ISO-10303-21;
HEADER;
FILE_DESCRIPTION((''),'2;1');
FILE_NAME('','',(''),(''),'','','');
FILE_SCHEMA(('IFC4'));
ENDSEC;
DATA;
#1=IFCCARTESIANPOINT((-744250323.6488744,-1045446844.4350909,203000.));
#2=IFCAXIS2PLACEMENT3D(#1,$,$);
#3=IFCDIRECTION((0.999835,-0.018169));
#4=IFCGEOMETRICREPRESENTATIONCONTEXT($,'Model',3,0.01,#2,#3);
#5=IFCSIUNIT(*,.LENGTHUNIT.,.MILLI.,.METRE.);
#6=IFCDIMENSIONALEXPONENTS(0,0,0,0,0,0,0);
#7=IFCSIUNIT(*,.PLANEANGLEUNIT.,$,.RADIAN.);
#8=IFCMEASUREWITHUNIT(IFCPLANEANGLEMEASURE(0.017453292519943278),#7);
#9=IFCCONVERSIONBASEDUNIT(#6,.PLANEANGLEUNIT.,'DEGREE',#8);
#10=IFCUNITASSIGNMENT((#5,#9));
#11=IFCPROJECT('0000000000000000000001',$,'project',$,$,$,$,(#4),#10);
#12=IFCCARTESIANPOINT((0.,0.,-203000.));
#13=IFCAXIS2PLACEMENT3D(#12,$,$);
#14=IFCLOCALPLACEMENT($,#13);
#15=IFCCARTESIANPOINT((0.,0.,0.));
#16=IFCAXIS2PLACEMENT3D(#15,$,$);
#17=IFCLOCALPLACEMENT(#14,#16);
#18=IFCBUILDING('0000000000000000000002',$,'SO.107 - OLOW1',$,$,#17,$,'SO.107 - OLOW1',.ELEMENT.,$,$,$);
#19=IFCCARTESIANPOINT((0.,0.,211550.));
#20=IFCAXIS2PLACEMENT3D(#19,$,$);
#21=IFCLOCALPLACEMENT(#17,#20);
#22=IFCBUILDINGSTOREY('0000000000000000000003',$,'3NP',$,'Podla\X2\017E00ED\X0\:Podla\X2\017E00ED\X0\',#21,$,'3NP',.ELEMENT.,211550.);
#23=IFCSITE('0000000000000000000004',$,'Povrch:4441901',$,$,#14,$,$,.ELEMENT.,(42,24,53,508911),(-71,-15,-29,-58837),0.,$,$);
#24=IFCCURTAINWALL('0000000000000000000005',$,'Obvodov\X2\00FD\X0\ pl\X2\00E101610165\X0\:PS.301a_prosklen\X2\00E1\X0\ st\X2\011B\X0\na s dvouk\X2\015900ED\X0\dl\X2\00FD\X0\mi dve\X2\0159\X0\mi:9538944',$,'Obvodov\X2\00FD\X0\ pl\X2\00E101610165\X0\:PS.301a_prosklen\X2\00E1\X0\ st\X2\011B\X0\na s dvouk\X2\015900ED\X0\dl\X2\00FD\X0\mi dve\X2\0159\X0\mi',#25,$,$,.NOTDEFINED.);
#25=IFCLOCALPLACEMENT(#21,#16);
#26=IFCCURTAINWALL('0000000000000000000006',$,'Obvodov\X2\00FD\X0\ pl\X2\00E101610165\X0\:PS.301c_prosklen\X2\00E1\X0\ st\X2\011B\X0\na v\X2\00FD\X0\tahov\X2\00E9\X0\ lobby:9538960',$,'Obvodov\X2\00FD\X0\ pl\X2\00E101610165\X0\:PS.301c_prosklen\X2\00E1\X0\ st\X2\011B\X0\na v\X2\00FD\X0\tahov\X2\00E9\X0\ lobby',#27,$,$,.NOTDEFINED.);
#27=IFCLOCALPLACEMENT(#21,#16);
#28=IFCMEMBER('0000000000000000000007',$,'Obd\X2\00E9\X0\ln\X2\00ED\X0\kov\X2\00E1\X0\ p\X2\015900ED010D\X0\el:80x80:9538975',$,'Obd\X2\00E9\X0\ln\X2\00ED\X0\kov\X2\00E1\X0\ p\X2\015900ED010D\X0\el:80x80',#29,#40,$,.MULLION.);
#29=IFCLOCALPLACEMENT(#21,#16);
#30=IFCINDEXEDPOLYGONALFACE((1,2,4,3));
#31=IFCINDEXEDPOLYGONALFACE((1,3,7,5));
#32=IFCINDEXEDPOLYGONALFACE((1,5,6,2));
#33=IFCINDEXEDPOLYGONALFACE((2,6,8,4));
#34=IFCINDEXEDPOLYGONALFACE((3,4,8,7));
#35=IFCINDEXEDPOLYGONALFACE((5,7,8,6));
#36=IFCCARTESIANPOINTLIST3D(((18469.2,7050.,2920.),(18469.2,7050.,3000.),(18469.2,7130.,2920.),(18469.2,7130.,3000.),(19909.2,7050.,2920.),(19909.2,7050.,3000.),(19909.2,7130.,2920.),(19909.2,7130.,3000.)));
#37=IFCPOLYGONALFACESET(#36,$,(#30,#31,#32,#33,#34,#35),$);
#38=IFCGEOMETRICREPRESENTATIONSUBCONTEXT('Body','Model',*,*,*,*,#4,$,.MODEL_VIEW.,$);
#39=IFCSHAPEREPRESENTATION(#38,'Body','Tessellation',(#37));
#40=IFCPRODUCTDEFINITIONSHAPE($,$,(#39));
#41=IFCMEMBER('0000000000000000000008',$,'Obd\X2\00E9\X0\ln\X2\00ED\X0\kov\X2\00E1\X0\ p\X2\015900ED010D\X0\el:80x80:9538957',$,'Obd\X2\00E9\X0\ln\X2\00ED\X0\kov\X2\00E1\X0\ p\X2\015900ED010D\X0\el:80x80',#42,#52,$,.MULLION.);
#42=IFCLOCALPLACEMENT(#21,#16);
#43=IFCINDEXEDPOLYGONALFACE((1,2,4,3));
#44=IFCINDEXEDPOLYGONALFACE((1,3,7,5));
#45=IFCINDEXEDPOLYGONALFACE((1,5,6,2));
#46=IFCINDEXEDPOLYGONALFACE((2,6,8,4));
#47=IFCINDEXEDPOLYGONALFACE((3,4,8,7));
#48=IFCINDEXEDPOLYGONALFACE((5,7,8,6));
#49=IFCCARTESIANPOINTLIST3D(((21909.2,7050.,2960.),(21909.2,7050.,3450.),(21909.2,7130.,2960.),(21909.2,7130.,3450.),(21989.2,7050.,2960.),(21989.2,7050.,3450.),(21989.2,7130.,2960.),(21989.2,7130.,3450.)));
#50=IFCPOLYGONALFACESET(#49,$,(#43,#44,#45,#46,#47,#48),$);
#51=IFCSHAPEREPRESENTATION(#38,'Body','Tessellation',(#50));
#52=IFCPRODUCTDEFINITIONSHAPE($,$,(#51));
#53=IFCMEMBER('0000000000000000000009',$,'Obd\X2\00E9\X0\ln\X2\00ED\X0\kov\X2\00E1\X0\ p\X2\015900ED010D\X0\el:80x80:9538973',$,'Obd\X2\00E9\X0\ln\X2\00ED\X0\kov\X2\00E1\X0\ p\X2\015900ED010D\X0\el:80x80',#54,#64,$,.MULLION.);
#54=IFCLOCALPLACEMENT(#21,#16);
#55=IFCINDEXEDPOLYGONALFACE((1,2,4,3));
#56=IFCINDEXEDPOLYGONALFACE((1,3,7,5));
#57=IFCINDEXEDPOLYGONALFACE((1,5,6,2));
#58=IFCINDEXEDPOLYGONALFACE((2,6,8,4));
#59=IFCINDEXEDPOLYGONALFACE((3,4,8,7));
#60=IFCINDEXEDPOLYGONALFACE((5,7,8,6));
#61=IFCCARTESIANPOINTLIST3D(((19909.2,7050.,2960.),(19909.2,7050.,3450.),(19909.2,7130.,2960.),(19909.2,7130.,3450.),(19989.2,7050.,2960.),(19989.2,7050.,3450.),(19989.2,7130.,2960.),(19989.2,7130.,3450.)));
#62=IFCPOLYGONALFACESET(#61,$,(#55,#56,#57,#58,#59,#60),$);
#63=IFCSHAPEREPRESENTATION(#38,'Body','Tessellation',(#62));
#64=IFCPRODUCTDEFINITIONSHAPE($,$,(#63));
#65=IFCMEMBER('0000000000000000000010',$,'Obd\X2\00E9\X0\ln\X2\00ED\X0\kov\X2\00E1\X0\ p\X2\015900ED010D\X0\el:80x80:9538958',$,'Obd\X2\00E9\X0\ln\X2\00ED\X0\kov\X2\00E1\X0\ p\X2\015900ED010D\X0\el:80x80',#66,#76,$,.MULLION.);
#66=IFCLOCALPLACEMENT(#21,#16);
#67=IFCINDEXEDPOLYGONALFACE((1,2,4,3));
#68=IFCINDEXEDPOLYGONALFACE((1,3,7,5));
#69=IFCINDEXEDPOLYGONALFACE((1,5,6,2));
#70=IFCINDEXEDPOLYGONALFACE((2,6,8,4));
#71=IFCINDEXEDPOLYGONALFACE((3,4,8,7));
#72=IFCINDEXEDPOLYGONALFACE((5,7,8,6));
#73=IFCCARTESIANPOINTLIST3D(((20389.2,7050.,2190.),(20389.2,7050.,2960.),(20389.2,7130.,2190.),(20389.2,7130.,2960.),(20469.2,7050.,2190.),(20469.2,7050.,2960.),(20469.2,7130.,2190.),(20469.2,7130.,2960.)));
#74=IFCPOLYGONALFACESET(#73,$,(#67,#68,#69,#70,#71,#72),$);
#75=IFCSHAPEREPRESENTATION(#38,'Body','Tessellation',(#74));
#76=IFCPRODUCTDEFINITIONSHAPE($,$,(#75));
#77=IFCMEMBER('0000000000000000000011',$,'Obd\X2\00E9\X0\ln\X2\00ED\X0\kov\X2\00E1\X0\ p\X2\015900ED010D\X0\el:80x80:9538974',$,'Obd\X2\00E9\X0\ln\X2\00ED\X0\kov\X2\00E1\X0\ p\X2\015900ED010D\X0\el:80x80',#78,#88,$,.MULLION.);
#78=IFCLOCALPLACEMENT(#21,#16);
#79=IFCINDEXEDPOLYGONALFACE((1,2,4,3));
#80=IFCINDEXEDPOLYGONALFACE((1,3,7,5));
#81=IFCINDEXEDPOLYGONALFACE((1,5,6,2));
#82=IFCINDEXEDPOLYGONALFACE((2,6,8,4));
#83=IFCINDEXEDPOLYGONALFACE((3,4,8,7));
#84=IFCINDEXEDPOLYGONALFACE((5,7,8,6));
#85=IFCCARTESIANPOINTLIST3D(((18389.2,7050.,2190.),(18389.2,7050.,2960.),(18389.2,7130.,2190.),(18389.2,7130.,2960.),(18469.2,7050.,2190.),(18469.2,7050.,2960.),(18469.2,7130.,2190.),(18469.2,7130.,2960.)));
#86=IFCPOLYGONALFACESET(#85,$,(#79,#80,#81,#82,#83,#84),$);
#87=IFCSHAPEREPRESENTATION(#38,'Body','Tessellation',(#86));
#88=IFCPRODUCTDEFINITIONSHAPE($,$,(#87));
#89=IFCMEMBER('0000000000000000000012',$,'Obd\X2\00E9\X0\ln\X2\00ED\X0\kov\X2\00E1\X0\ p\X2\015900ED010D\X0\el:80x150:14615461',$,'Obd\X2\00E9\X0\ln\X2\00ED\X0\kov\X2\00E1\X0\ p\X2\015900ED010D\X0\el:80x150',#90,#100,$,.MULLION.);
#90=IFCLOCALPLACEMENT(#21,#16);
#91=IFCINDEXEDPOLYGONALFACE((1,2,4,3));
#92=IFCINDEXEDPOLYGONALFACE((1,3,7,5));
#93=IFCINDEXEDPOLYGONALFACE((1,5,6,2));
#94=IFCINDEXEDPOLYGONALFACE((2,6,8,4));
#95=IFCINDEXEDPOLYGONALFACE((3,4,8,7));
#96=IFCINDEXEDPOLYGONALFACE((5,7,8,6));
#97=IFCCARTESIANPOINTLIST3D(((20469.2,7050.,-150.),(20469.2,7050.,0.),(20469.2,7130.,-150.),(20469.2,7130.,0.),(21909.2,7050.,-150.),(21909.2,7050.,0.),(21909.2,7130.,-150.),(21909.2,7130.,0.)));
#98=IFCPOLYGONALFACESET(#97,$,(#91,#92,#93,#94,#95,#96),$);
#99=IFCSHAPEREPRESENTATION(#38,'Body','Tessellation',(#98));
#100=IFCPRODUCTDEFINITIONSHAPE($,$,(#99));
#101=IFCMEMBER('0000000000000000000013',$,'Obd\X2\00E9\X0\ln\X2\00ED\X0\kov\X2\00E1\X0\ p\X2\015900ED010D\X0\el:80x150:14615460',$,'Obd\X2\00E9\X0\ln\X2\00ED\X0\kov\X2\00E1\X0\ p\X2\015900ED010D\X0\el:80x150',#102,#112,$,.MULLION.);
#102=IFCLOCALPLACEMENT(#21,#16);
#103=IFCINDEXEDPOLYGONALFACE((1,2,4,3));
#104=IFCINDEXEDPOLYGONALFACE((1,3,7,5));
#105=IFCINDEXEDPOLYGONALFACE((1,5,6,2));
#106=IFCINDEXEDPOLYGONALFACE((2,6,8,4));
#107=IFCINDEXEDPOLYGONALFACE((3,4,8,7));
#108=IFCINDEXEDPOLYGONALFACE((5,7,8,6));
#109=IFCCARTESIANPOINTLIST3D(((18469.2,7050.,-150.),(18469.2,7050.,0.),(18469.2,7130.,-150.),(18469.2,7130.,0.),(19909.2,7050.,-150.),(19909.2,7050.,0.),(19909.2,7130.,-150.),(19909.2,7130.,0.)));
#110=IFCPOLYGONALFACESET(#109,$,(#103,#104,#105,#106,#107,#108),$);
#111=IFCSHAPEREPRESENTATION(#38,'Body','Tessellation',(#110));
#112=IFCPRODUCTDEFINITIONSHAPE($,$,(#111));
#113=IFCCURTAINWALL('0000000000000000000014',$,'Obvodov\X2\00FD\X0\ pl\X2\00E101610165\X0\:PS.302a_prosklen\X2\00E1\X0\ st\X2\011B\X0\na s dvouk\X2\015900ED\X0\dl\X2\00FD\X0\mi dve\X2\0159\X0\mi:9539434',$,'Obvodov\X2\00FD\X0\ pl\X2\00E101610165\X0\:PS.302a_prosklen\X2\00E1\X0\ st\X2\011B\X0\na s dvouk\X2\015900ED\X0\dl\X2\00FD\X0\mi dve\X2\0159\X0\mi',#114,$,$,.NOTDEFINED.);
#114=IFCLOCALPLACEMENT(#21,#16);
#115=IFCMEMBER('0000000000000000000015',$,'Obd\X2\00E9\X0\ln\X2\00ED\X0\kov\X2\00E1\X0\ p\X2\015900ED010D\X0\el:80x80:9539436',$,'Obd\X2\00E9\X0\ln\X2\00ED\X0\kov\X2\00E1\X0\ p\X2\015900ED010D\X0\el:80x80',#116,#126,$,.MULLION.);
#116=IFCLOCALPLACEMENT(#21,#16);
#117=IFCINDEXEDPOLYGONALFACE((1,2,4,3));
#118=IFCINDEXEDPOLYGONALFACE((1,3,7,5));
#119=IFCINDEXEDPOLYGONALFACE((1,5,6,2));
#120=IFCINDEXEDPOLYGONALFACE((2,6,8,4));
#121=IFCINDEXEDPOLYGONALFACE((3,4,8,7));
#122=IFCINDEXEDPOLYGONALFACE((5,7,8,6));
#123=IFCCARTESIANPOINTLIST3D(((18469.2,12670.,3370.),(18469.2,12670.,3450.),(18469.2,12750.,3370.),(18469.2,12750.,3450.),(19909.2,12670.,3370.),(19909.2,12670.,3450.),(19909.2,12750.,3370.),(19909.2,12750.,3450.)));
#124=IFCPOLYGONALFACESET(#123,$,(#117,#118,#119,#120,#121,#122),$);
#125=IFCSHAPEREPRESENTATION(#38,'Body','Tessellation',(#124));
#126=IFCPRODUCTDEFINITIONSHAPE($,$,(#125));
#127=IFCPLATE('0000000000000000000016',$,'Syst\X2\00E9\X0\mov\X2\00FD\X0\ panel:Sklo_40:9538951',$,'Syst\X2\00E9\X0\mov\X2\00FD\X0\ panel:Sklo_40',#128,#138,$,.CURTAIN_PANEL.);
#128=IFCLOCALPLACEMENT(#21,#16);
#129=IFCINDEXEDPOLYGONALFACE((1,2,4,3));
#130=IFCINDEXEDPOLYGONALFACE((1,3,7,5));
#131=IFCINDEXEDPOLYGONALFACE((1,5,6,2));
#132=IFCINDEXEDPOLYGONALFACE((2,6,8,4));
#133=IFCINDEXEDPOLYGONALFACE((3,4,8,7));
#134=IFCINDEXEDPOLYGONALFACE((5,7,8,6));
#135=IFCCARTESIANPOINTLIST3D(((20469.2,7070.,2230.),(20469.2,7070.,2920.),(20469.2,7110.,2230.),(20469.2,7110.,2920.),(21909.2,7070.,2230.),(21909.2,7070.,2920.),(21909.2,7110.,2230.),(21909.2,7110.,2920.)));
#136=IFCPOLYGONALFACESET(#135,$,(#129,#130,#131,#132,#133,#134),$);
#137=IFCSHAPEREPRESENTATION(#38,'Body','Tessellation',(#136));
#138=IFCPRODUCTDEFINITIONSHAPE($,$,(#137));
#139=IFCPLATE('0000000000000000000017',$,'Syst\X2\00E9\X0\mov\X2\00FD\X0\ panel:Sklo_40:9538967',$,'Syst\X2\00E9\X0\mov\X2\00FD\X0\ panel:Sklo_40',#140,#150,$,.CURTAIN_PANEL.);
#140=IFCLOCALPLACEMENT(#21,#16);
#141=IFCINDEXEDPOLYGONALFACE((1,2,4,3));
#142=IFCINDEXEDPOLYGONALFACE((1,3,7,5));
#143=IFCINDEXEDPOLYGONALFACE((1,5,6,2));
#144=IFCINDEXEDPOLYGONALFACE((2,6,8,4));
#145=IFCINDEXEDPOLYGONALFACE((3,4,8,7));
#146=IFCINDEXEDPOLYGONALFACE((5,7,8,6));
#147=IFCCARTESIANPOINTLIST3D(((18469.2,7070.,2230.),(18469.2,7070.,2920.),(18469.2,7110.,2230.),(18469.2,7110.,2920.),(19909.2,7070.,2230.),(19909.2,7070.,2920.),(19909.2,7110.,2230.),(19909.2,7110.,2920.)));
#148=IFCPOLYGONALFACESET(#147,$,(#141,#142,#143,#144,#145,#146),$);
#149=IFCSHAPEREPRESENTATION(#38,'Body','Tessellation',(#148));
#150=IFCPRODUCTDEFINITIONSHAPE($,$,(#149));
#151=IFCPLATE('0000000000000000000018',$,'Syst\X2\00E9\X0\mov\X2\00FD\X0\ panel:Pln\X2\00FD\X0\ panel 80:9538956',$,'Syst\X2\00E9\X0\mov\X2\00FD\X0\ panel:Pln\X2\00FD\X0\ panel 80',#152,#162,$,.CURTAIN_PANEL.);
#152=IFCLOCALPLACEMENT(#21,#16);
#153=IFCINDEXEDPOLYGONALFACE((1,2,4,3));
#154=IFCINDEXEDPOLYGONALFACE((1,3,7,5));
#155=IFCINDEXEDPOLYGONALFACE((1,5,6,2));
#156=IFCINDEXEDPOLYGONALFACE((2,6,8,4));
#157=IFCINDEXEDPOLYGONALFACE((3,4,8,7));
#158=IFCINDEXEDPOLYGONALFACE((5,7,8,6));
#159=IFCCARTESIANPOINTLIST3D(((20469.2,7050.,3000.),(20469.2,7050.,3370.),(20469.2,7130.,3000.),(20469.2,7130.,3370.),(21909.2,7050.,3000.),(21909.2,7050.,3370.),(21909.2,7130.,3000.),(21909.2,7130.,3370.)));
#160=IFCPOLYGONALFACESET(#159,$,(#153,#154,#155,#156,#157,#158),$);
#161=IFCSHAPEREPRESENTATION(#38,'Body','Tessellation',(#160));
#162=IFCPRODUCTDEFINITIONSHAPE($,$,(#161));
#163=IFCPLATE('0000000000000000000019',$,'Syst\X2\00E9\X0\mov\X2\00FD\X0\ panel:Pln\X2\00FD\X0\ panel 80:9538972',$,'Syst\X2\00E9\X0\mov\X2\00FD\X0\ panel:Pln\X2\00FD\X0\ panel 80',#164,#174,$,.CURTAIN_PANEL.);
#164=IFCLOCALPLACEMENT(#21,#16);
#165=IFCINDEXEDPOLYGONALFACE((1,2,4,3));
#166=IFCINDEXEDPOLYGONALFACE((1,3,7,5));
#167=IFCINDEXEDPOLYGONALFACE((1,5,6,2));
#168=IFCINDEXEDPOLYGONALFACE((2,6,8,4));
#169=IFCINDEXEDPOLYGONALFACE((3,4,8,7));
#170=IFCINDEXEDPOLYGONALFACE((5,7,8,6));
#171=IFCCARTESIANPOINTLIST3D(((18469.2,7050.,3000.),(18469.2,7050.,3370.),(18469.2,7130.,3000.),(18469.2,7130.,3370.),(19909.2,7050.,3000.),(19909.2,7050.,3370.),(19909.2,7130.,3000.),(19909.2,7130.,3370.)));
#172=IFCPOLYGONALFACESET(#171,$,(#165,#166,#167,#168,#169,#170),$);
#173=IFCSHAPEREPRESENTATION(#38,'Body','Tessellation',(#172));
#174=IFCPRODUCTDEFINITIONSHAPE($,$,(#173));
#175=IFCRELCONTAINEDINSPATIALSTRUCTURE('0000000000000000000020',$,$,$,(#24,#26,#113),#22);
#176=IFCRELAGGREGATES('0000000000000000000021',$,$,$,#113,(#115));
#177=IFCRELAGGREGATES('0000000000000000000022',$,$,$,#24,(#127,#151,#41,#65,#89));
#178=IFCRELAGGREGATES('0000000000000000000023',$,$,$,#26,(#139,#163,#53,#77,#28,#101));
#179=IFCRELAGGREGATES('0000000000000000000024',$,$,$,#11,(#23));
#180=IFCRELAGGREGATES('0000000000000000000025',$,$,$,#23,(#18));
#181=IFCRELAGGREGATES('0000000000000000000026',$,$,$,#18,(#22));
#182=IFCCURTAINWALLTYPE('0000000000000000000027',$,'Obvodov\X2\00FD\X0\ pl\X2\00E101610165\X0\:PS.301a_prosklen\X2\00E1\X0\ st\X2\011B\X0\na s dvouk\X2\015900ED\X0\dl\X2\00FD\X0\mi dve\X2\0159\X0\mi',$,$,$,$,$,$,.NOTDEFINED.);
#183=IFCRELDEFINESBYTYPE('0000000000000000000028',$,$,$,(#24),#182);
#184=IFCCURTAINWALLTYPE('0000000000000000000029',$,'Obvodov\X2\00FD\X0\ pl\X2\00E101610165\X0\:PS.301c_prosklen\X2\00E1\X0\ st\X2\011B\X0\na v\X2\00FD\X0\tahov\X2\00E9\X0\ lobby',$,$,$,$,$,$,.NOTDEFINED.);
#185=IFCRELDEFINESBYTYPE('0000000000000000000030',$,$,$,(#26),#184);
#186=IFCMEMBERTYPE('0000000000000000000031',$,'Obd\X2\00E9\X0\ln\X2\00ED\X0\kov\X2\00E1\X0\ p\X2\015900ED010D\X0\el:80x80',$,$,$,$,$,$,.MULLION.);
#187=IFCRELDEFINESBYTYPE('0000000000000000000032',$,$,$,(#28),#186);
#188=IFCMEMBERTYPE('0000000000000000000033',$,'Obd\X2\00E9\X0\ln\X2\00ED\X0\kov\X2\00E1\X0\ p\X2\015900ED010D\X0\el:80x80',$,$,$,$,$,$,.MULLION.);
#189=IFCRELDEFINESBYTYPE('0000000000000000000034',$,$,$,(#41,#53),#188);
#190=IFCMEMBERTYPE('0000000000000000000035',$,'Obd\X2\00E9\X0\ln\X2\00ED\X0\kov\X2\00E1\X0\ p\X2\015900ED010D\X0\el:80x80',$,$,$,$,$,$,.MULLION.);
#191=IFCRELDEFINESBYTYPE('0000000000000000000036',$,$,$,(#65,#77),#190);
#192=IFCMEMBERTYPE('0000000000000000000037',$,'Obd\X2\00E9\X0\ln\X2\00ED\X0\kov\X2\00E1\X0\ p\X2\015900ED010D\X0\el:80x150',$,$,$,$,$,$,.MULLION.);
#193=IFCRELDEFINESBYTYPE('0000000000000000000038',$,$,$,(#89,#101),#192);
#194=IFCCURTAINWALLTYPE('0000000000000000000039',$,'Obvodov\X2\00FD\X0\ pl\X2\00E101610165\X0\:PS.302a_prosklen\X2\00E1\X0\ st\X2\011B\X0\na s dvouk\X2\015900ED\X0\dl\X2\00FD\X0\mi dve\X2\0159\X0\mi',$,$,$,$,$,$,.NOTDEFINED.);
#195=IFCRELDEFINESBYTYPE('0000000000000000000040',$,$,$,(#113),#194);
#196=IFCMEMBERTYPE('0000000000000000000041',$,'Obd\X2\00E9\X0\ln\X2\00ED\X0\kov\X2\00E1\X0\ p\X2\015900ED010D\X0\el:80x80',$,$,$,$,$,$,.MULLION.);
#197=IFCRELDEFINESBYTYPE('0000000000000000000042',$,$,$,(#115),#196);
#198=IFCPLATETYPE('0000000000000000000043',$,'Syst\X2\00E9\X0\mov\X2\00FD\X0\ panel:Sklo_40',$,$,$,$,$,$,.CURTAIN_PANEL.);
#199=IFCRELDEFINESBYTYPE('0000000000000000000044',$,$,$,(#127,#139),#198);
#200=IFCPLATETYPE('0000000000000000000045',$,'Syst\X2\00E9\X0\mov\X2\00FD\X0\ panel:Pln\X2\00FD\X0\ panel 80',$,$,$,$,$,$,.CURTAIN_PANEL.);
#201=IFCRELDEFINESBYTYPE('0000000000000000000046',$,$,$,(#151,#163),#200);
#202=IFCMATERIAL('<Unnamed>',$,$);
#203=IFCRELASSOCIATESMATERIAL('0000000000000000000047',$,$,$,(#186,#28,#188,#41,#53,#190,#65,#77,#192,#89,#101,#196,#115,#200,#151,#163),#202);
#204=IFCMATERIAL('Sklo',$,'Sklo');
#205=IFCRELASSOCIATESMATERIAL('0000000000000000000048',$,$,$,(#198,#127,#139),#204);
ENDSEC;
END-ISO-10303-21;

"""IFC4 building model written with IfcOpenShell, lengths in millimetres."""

from ifc_helpers import new_model, entity, si_unit, converted_unit, direction, frame, origin, place, context, subcontext, project, spatial, indexed_curve, outline, extrude, source, transform, mapped, material, type_object, type_shapes, element, aggregate, save


model = new_model("IFC4")

# Units and contexts
model_context = context("Model", 3, precision=0.01, world=frame((-744250323.6488744, -1045446844.4350909, 203000.0)), true_north=direction((0.999835, -0.018169)))
body_context = subcontext(model_context, "Body", "Model", "MODEL_VIEW")
ifc_project = project(units=[si_unit("LENGTHUNIT", "METRE", prefix="MILLI"), converted_unit("PLANEANGLEUNIT", "DEGREE", entity("IfcPlaneAngleMeasure", 0.017453292519943278), si_unit("PLANEANGLEUNIT", "RADIAN"), dimensions=[0, 0, 0, 0, 0, 0, 0])], contexts=[model_context])

# Site, building, storey
site_placement = place(None, frame((0.0, 0.0, -203000.0)))
site = spatial("IfcSite", under=ifc_project, at=site_placement, Name="Povrch:4441901", CompositionType="ELEMENT", RefLatitude=(42, 24, 53, 508911), RefLongitude=(-71, -15, -29, -58837), RefElevation=0.0)
building_placement = place(site_placement, origin())
building = spatial("IfcBuilding", under=site, at=building_placement, Name="SO.107 - OLOW1", LongName="SO.107 - OLOW1", CompositionType="ELEMENT")
storey_placement = place(building_placement, frame((0.0, 0.0, 211550.0)))
storey = spatial("IfcBuildingStorey", under=building, at=storey_placement, Name="3NP", ObjectType="Podlaží:Podlaží", LongName="3NP", CompositionType="ELEMENT", Elevation=211550.0)

# Curtain walls
curtain_wall_type_1 = type_object("IfcCurtainWallType", Name="Obvodový plášť:PS.301a_prosklená stěna s dvoukřídlými dveřmi", PredefinedType="NOTDEFINED")
curtain_wall_1_placement = place(storey_placement, frame((0.0, 0.0, -211550.0)))
curtain_wall_1 = element("IfcCurtainWall", 1, at=curtain_wall_1_placement, inside=storey, type_object=curtain_wall_type_1, Name="Obvodový plášť:PS.301a_prosklená stěna s dvoukřídlými dveřmi:9538944", ObjectType="Obvodový plášť:PS.301a_prosklená stěna s dvoukřídlými dveřmi", PredefinedType="NOTDEFINED")
ifc_material_1 = material(Name="<Unnamed>")
curtain_wall_type_2 = type_object("IfcCurtainWallType", Name="Obvodový plášť:PS.301c_prosklená stěna výtahové lobby", PredefinedType="NOTDEFINED")
curtain_wall_2_placement = place(storey_placement, frame((0.0, 0.0, -211550.0)))
curtain_wall_2 = element("IfcCurtainWall", 2, at=curtain_wall_2_placement, inside=storey, type_object=curtain_wall_type_2, Name="Obvodový plášť:PS.301c_prosklená stěna výtahové lobby:9538960", ObjectType="Obvodový plášť:PS.301c_prosklená stěna výtahové lobby", PredefinedType="NOTDEFINED")

# Members
member_type_1 = type_object("IfcMemberType", Name="Obdélníková příčel:80x80", PredefinedType="MULLION", material=ifc_material_1)
shared_shape_1 = source(origin(), body_context, "Body", "SweptSolid", [
    extrude(outline(indexed_curve([(-40.0, -40.0), (40.0, -40.0), (40.0, 40.0), (-40.0, 40.0), (-40.0, -40.0)], self_intersect=False)), frame((0.0, 0.0, -1440.0), z_axis=(0.0, 0.0, 1.0), x_axis=(-1.0, 0.0, 0.0)), (0.0, 0.0, 1.0), 1440.0),
])
type_shapes(member_type_1, [shared_shape_1])
member_1_placement = place(curtain_wall_2_placement, frame((19909.2, 7090.0, 214510.0), z_axis=(1.0, 0.0, 0.0), x_axis=(0.0, 0.0, 1.0)))
member_1 = element("IfcMember", 3, at=member_1_placement, type_object=member_type_1, material=ifc_material_1, Name="Obdélníková příčel:80x80:9538975", ObjectType="Obdélníková příčel:80x80", PredefinedType="MULLION", context=body_context, shape_type="MappedRepresentation", body=[
    mapped(shared_shape_1, transform((0.0, 0.0, 0.0), scale=1.0)),
])
member_type_2 = type_object("IfcMemberType", Name="Obdélníková příčel:80x80", PredefinedType="MULLION", material=ifc_material_1)
shared_shape_2 = source(origin(), body_context, "Body", "SweptSolid", [
    extrude(outline(indexed_curve([(-40.0, -40.0), (40.0, -40.0), (40.0, 40.0), (-40.0, 40.0), (-40.0, -40.0)], self_intersect=False)), frame((-40.0, 0.0, -490.0), z_axis=(0.0, 0.0, 1.0), x_axis=(-1.0, 0.0, 0.0)), (0.0, 0.0, 1.0), 490.0),
])
type_shapes(member_type_2, [shared_shape_2])
member_2_placement = place(curtain_wall_1_placement, frame((21989.2, 7090.0, 214510.0), z_axis=(0.0, 0.0, -1.0), x_axis=(1.0, 0.0, 0.0)))
member_2 = element("IfcMember", 4, at=member_2_placement, type_object=member_type_2, material=ifc_material_1, Name="Obdélníková příčel:80x80:9538957", ObjectType="Obdélníková příčel:80x80", PredefinedType="MULLION", context=body_context, shape_type="MappedRepresentation", body=[
    mapped(shared_shape_2, transform((0.0, 0.0, 0.0), scale=1.0)),
])
member_3_placement = place(curtain_wall_2_placement, frame((19989.2, 7090.0, 214510.0), z_axis=(0.0, 0.0, -1.0), x_axis=(1.0, 0.0, 0.0)))
member_3 = element("IfcMember", 5, at=member_3_placement, type_object=member_type_2, material=ifc_material_1, Name="Obdélníková příčel:80x80:9538973", ObjectType="Obdélníková příčel:80x80", PredefinedType="MULLION", context=body_context, shape_type="MappedRepresentation", body=[
    mapped(shared_shape_2, transform((0.0, 0.0, 0.0), scale=1.0)),
])
member_type_3 = type_object("IfcMemberType", Name="Obdélníková příčel:80x80", PredefinedType="MULLION", material=ifc_material_1)
shared_shape_3 = source(origin(), body_context, "Body", "SweptSolid", [
    extrude(outline(indexed_curve([(-40.0, -40.0), (40.0, -40.0), (40.0, 40.0), (-40.0, 40.0), (-40.0, -40.0)], self_intersect=False)), frame((-40.0, 0.0, -770.0), z_axis=(0.0, 0.0, 1.0), x_axis=(-1.0, 0.0, 0.0)), (0.0, 0.0, 1.0), 770.0),
])
type_shapes(member_type_3, [shared_shape_3])
member_4_placement = place(curtain_wall_1_placement, frame((20389.2, 7090.0, 214510.0), z_axis=(0.0, 0.0, 1.0), x_axis=(-1.0, 0.0, 0.0)))
member_4 = element("IfcMember", 6, at=member_4_placement, type_object=member_type_3, material=ifc_material_1, Name="Obdélníková příčel:80x80:9538958", ObjectType="Obdélníková příčel:80x80", PredefinedType="MULLION", context=body_context, shape_type="MappedRepresentation", body=[
    mapped(shared_shape_3, transform((0.0, 0.0, 0.0), scale=1.0)),
])
member_5_placement = place(curtain_wall_2_placement, frame((18389.2, 7090.0, 214510.0), z_axis=(0.0, 0.0, 1.0), x_axis=(-1.0, 0.0, 0.0)))
member_5 = element("IfcMember", 7, at=member_5_placement, type_object=member_type_3, material=ifc_material_1, Name="Obdélníková příčel:80x80:9538974", ObjectType="Obdélníková příčel:80x80", PredefinedType="MULLION", context=body_context, shape_type="MappedRepresentation", body=[
    mapped(shared_shape_3, transform((0.0, 0.0, 0.0), scale=1.0)),
])
member_type_4 = type_object("IfcMemberType", Name="Obdélníková příčel:80x150", PredefinedType="MULLION", material=ifc_material_1)
shared_shape_4 = source(origin(), body_context, "Body", "SweptSolid", [
    extrude(outline(indexed_curve([(-75.0, -40.0), (75.0, -40.0), (75.0, 40.0), (-75.0, 40.0), (-75.0, -40.0)], self_intersect=False)), frame((-75.0, 0.0, -1440.0), z_axis=(0.0, 0.0, 1.0), x_axis=(-1.0, 0.0, 0.0)), (0.0, 0.0, 1.0), 1440.0),
])
type_shapes(member_type_4, [shared_shape_4])
member_6_placement = place(curtain_wall_1_placement, frame((20469.2, 7090.0, 211400.0), z_axis=(-1.0, 0.0, 0.0), x_axis=(0.0, 0.0, -1.0)))
member_6 = element("IfcMember", 8, at=member_6_placement, type_object=member_type_4, material=ifc_material_1, Name="Obdélníková příčel:80x150:14615461", ObjectType="Obdélníková příčel:80x150", PredefinedType="MULLION", context=body_context, shape_type="MappedRepresentation", body=[
    mapped(shared_shape_4, transform((0.0, 0.0, 0.0), scale=1.0)),
])
member_7_placement = place(curtain_wall_2_placement, frame((18469.2, 7090.0, 211400.0), z_axis=(-1.0, 0.0, 0.0), x_axis=(0.0, 0.0, -1.0)))
member_7 = element("IfcMember", 9, at=member_7_placement, type_object=member_type_4, material=ifc_material_1, Name="Obdélníková příčel:80x150:14615460", ObjectType="Obdélníková příčel:80x150", PredefinedType="MULLION", context=body_context, shape_type="MappedRepresentation", body=[
    mapped(shared_shape_4, transform((0.0, 0.0, 0.0), scale=1.0)),
])

# Curtain wall, member
curtain_wall_type_3 = type_object("IfcCurtainWallType", Name="Obvodový plášť:PS.302a_prosklená stěna s dvoukřídlými dveřmi", PredefinedType="NOTDEFINED")
curtain_wall_3_placement = place(storey_placement, frame((0.0, 0.0, -211550.0)))
curtain_wall_3 = element("IfcCurtainWall", 10, at=curtain_wall_3_placement, inside=storey, type_object=curtain_wall_type_3, Name="Obvodový plášť:PS.302a_prosklená stěna s dvoukřídlými dveřmi:9539434", ObjectType="Obvodový plášť:PS.302a_prosklená stěna s dvoukřídlými dveřmi", PredefinedType="NOTDEFINED")
member_type_5 = type_object("IfcMemberType", Name="Obdélníková příčel:80x80", PredefinedType="MULLION", material=ifc_material_1)
shared_shape_5 = source(origin(), body_context, "Body", "SweptSolid", [
    extrude(outline(indexed_curve([(-40.0, -40.0), (40.0, -40.0), (40.0, 40.0), (-40.0, 40.0), (-40.0, -40.0)], self_intersect=False)), frame((-40.0, 0.0, -1440.0), z_axis=(0.0, 0.0, 1.0), x_axis=(-1.0, 0.0, 0.0)), (0.0, 0.0, 1.0), 1440.0),
])
type_shapes(member_type_5, [shared_shape_5])
member_8_placement = place(curtain_wall_3_placement, frame((19909.2, 12710.0, 215000.0), z_axis=(1.0, 0.0, 0.0), x_axis=(0.0, 0.0, 1.0)))
member_8 = element("IfcMember", 11, at=member_8_placement, type_object=member_type_5, material=ifc_material_1, Name="Obdélníková příčel:80x80:9539436", ObjectType="Obdélníková příčel:80x80", PredefinedType="MULLION", context=body_context, shape_type="MappedRepresentation", body=[
    mapped(shared_shape_5, transform((0.0, 0.0, 0.0), scale=1.0)),
])
aggregate(curtain_wall_3, [member_8])

# Plates
ifc_material_2 = material(Name="Sklo", Category="Sklo")
plate_type_1 = type_object("IfcPlateType", Name="Systémový panel:Sklo_40", PredefinedType="CURTAIN_PANEL", material=ifc_material_2)
shared_shape_6 = source(origin(), body_context, "Body", "SweptSolid", [
    extrude(outline(indexed_curve([(-20.0, -720.0), (20.0, -720.0), (20.0, 720.0), (-20.0, 720.0), (-20.0, -720.0)], self_intersect=False)), frame((0.0, 0.0, 0.0), z_axis=(0.0, 0.0, 1.0), x_axis=(0.0, 1.0, 0.0)), (0.0, 0.0, 1.0), 690.0),
])
type_shapes(plate_type_1, [shared_shape_6])
plate_1_placement = place(curtain_wall_1_placement, frame((21189.2, 7090.0, 213780.0)))
plate_1 = element("IfcPlate", 12, at=plate_1_placement, type_object=plate_type_1, material=ifc_material_2, Name="Systémový panel:Sklo_40:9538951", ObjectType="Systémový panel:Sklo_40", PredefinedType="CURTAIN_PANEL", context=body_context, shape_type="MappedRepresentation", body=[
    mapped(shared_shape_6, transform((0.0, 0.0, 0.0), scale=1.0)),
])
plate_2_placement = place(curtain_wall_2_placement, frame((19189.2, 7090.0, 213780.0)))
plate_2 = element("IfcPlate", 13, at=plate_2_placement, type_object=plate_type_1, material=ifc_material_2, Name="Systémový panel:Sklo_40:9538967", ObjectType="Systémový panel:Sklo_40", PredefinedType="CURTAIN_PANEL", context=body_context, shape_type="MappedRepresentation", body=[
    mapped(shared_shape_6, transform((0.0, 0.0, 0.0), scale=1.0)),
])
plate_type_2 = type_object("IfcPlateType", Name="Systémový panel:Plný panel 80", PredefinedType="CURTAIN_PANEL", material=ifc_material_1)
shared_shape_7 = source(origin(), body_context, "Body", "SweptSolid", [
    extrude(outline(indexed_curve([(-40.0, -720.0), (40.0, -720.0), (40.0, 720.0), (-40.0, 720.0), (-40.0, -720.0)], self_intersect=False)), frame((0.0, 0.0, 0.0), z_axis=(0.0, 0.0, 1.0), x_axis=(0.0, 1.0, 0.0)), (0.0, 0.0, 1.0), 370.0),
])
type_shapes(plate_type_2, [shared_shape_7])
plate_3_placement = place(curtain_wall_1_placement, frame((21189.2, 7090.0, 214550.0)))
plate_3 = element("IfcPlate", 14, at=plate_3_placement, type_object=plate_type_2, material=ifc_material_1, Name="Systémový panel:Plný panel 80:9538956", ObjectType="Systémový panel:Plný panel 80", PredefinedType="CURTAIN_PANEL", context=body_context, shape_type="MappedRepresentation", body=[
    mapped(shared_shape_7, transform((0.0, 0.0, 0.0), scale=1.0)),
])
plate_4_placement = place(curtain_wall_2_placement, frame((19189.2, 7090.0, 214550.0)))
plate_4 = element("IfcPlate", 15, at=plate_4_placement, type_object=plate_type_2, material=ifc_material_1, Name="Systémový panel:Plný panel 80:9538972", ObjectType="Systémový panel:Plný panel 80", PredefinedType="CURTAIN_PANEL", context=body_context, shape_type="MappedRepresentation", body=[
    mapped(shared_shape_7, transform((0.0, 0.0, 0.0), scale=1.0)),
])

aggregate(curtain_wall_1, [plate_1, plate_3, member_2, member_4, member_6])
aggregate(curtain_wall_2, [plate_2, plate_4, member_3, member_5, member_1, member_7])

save(model, "model.ifc")
